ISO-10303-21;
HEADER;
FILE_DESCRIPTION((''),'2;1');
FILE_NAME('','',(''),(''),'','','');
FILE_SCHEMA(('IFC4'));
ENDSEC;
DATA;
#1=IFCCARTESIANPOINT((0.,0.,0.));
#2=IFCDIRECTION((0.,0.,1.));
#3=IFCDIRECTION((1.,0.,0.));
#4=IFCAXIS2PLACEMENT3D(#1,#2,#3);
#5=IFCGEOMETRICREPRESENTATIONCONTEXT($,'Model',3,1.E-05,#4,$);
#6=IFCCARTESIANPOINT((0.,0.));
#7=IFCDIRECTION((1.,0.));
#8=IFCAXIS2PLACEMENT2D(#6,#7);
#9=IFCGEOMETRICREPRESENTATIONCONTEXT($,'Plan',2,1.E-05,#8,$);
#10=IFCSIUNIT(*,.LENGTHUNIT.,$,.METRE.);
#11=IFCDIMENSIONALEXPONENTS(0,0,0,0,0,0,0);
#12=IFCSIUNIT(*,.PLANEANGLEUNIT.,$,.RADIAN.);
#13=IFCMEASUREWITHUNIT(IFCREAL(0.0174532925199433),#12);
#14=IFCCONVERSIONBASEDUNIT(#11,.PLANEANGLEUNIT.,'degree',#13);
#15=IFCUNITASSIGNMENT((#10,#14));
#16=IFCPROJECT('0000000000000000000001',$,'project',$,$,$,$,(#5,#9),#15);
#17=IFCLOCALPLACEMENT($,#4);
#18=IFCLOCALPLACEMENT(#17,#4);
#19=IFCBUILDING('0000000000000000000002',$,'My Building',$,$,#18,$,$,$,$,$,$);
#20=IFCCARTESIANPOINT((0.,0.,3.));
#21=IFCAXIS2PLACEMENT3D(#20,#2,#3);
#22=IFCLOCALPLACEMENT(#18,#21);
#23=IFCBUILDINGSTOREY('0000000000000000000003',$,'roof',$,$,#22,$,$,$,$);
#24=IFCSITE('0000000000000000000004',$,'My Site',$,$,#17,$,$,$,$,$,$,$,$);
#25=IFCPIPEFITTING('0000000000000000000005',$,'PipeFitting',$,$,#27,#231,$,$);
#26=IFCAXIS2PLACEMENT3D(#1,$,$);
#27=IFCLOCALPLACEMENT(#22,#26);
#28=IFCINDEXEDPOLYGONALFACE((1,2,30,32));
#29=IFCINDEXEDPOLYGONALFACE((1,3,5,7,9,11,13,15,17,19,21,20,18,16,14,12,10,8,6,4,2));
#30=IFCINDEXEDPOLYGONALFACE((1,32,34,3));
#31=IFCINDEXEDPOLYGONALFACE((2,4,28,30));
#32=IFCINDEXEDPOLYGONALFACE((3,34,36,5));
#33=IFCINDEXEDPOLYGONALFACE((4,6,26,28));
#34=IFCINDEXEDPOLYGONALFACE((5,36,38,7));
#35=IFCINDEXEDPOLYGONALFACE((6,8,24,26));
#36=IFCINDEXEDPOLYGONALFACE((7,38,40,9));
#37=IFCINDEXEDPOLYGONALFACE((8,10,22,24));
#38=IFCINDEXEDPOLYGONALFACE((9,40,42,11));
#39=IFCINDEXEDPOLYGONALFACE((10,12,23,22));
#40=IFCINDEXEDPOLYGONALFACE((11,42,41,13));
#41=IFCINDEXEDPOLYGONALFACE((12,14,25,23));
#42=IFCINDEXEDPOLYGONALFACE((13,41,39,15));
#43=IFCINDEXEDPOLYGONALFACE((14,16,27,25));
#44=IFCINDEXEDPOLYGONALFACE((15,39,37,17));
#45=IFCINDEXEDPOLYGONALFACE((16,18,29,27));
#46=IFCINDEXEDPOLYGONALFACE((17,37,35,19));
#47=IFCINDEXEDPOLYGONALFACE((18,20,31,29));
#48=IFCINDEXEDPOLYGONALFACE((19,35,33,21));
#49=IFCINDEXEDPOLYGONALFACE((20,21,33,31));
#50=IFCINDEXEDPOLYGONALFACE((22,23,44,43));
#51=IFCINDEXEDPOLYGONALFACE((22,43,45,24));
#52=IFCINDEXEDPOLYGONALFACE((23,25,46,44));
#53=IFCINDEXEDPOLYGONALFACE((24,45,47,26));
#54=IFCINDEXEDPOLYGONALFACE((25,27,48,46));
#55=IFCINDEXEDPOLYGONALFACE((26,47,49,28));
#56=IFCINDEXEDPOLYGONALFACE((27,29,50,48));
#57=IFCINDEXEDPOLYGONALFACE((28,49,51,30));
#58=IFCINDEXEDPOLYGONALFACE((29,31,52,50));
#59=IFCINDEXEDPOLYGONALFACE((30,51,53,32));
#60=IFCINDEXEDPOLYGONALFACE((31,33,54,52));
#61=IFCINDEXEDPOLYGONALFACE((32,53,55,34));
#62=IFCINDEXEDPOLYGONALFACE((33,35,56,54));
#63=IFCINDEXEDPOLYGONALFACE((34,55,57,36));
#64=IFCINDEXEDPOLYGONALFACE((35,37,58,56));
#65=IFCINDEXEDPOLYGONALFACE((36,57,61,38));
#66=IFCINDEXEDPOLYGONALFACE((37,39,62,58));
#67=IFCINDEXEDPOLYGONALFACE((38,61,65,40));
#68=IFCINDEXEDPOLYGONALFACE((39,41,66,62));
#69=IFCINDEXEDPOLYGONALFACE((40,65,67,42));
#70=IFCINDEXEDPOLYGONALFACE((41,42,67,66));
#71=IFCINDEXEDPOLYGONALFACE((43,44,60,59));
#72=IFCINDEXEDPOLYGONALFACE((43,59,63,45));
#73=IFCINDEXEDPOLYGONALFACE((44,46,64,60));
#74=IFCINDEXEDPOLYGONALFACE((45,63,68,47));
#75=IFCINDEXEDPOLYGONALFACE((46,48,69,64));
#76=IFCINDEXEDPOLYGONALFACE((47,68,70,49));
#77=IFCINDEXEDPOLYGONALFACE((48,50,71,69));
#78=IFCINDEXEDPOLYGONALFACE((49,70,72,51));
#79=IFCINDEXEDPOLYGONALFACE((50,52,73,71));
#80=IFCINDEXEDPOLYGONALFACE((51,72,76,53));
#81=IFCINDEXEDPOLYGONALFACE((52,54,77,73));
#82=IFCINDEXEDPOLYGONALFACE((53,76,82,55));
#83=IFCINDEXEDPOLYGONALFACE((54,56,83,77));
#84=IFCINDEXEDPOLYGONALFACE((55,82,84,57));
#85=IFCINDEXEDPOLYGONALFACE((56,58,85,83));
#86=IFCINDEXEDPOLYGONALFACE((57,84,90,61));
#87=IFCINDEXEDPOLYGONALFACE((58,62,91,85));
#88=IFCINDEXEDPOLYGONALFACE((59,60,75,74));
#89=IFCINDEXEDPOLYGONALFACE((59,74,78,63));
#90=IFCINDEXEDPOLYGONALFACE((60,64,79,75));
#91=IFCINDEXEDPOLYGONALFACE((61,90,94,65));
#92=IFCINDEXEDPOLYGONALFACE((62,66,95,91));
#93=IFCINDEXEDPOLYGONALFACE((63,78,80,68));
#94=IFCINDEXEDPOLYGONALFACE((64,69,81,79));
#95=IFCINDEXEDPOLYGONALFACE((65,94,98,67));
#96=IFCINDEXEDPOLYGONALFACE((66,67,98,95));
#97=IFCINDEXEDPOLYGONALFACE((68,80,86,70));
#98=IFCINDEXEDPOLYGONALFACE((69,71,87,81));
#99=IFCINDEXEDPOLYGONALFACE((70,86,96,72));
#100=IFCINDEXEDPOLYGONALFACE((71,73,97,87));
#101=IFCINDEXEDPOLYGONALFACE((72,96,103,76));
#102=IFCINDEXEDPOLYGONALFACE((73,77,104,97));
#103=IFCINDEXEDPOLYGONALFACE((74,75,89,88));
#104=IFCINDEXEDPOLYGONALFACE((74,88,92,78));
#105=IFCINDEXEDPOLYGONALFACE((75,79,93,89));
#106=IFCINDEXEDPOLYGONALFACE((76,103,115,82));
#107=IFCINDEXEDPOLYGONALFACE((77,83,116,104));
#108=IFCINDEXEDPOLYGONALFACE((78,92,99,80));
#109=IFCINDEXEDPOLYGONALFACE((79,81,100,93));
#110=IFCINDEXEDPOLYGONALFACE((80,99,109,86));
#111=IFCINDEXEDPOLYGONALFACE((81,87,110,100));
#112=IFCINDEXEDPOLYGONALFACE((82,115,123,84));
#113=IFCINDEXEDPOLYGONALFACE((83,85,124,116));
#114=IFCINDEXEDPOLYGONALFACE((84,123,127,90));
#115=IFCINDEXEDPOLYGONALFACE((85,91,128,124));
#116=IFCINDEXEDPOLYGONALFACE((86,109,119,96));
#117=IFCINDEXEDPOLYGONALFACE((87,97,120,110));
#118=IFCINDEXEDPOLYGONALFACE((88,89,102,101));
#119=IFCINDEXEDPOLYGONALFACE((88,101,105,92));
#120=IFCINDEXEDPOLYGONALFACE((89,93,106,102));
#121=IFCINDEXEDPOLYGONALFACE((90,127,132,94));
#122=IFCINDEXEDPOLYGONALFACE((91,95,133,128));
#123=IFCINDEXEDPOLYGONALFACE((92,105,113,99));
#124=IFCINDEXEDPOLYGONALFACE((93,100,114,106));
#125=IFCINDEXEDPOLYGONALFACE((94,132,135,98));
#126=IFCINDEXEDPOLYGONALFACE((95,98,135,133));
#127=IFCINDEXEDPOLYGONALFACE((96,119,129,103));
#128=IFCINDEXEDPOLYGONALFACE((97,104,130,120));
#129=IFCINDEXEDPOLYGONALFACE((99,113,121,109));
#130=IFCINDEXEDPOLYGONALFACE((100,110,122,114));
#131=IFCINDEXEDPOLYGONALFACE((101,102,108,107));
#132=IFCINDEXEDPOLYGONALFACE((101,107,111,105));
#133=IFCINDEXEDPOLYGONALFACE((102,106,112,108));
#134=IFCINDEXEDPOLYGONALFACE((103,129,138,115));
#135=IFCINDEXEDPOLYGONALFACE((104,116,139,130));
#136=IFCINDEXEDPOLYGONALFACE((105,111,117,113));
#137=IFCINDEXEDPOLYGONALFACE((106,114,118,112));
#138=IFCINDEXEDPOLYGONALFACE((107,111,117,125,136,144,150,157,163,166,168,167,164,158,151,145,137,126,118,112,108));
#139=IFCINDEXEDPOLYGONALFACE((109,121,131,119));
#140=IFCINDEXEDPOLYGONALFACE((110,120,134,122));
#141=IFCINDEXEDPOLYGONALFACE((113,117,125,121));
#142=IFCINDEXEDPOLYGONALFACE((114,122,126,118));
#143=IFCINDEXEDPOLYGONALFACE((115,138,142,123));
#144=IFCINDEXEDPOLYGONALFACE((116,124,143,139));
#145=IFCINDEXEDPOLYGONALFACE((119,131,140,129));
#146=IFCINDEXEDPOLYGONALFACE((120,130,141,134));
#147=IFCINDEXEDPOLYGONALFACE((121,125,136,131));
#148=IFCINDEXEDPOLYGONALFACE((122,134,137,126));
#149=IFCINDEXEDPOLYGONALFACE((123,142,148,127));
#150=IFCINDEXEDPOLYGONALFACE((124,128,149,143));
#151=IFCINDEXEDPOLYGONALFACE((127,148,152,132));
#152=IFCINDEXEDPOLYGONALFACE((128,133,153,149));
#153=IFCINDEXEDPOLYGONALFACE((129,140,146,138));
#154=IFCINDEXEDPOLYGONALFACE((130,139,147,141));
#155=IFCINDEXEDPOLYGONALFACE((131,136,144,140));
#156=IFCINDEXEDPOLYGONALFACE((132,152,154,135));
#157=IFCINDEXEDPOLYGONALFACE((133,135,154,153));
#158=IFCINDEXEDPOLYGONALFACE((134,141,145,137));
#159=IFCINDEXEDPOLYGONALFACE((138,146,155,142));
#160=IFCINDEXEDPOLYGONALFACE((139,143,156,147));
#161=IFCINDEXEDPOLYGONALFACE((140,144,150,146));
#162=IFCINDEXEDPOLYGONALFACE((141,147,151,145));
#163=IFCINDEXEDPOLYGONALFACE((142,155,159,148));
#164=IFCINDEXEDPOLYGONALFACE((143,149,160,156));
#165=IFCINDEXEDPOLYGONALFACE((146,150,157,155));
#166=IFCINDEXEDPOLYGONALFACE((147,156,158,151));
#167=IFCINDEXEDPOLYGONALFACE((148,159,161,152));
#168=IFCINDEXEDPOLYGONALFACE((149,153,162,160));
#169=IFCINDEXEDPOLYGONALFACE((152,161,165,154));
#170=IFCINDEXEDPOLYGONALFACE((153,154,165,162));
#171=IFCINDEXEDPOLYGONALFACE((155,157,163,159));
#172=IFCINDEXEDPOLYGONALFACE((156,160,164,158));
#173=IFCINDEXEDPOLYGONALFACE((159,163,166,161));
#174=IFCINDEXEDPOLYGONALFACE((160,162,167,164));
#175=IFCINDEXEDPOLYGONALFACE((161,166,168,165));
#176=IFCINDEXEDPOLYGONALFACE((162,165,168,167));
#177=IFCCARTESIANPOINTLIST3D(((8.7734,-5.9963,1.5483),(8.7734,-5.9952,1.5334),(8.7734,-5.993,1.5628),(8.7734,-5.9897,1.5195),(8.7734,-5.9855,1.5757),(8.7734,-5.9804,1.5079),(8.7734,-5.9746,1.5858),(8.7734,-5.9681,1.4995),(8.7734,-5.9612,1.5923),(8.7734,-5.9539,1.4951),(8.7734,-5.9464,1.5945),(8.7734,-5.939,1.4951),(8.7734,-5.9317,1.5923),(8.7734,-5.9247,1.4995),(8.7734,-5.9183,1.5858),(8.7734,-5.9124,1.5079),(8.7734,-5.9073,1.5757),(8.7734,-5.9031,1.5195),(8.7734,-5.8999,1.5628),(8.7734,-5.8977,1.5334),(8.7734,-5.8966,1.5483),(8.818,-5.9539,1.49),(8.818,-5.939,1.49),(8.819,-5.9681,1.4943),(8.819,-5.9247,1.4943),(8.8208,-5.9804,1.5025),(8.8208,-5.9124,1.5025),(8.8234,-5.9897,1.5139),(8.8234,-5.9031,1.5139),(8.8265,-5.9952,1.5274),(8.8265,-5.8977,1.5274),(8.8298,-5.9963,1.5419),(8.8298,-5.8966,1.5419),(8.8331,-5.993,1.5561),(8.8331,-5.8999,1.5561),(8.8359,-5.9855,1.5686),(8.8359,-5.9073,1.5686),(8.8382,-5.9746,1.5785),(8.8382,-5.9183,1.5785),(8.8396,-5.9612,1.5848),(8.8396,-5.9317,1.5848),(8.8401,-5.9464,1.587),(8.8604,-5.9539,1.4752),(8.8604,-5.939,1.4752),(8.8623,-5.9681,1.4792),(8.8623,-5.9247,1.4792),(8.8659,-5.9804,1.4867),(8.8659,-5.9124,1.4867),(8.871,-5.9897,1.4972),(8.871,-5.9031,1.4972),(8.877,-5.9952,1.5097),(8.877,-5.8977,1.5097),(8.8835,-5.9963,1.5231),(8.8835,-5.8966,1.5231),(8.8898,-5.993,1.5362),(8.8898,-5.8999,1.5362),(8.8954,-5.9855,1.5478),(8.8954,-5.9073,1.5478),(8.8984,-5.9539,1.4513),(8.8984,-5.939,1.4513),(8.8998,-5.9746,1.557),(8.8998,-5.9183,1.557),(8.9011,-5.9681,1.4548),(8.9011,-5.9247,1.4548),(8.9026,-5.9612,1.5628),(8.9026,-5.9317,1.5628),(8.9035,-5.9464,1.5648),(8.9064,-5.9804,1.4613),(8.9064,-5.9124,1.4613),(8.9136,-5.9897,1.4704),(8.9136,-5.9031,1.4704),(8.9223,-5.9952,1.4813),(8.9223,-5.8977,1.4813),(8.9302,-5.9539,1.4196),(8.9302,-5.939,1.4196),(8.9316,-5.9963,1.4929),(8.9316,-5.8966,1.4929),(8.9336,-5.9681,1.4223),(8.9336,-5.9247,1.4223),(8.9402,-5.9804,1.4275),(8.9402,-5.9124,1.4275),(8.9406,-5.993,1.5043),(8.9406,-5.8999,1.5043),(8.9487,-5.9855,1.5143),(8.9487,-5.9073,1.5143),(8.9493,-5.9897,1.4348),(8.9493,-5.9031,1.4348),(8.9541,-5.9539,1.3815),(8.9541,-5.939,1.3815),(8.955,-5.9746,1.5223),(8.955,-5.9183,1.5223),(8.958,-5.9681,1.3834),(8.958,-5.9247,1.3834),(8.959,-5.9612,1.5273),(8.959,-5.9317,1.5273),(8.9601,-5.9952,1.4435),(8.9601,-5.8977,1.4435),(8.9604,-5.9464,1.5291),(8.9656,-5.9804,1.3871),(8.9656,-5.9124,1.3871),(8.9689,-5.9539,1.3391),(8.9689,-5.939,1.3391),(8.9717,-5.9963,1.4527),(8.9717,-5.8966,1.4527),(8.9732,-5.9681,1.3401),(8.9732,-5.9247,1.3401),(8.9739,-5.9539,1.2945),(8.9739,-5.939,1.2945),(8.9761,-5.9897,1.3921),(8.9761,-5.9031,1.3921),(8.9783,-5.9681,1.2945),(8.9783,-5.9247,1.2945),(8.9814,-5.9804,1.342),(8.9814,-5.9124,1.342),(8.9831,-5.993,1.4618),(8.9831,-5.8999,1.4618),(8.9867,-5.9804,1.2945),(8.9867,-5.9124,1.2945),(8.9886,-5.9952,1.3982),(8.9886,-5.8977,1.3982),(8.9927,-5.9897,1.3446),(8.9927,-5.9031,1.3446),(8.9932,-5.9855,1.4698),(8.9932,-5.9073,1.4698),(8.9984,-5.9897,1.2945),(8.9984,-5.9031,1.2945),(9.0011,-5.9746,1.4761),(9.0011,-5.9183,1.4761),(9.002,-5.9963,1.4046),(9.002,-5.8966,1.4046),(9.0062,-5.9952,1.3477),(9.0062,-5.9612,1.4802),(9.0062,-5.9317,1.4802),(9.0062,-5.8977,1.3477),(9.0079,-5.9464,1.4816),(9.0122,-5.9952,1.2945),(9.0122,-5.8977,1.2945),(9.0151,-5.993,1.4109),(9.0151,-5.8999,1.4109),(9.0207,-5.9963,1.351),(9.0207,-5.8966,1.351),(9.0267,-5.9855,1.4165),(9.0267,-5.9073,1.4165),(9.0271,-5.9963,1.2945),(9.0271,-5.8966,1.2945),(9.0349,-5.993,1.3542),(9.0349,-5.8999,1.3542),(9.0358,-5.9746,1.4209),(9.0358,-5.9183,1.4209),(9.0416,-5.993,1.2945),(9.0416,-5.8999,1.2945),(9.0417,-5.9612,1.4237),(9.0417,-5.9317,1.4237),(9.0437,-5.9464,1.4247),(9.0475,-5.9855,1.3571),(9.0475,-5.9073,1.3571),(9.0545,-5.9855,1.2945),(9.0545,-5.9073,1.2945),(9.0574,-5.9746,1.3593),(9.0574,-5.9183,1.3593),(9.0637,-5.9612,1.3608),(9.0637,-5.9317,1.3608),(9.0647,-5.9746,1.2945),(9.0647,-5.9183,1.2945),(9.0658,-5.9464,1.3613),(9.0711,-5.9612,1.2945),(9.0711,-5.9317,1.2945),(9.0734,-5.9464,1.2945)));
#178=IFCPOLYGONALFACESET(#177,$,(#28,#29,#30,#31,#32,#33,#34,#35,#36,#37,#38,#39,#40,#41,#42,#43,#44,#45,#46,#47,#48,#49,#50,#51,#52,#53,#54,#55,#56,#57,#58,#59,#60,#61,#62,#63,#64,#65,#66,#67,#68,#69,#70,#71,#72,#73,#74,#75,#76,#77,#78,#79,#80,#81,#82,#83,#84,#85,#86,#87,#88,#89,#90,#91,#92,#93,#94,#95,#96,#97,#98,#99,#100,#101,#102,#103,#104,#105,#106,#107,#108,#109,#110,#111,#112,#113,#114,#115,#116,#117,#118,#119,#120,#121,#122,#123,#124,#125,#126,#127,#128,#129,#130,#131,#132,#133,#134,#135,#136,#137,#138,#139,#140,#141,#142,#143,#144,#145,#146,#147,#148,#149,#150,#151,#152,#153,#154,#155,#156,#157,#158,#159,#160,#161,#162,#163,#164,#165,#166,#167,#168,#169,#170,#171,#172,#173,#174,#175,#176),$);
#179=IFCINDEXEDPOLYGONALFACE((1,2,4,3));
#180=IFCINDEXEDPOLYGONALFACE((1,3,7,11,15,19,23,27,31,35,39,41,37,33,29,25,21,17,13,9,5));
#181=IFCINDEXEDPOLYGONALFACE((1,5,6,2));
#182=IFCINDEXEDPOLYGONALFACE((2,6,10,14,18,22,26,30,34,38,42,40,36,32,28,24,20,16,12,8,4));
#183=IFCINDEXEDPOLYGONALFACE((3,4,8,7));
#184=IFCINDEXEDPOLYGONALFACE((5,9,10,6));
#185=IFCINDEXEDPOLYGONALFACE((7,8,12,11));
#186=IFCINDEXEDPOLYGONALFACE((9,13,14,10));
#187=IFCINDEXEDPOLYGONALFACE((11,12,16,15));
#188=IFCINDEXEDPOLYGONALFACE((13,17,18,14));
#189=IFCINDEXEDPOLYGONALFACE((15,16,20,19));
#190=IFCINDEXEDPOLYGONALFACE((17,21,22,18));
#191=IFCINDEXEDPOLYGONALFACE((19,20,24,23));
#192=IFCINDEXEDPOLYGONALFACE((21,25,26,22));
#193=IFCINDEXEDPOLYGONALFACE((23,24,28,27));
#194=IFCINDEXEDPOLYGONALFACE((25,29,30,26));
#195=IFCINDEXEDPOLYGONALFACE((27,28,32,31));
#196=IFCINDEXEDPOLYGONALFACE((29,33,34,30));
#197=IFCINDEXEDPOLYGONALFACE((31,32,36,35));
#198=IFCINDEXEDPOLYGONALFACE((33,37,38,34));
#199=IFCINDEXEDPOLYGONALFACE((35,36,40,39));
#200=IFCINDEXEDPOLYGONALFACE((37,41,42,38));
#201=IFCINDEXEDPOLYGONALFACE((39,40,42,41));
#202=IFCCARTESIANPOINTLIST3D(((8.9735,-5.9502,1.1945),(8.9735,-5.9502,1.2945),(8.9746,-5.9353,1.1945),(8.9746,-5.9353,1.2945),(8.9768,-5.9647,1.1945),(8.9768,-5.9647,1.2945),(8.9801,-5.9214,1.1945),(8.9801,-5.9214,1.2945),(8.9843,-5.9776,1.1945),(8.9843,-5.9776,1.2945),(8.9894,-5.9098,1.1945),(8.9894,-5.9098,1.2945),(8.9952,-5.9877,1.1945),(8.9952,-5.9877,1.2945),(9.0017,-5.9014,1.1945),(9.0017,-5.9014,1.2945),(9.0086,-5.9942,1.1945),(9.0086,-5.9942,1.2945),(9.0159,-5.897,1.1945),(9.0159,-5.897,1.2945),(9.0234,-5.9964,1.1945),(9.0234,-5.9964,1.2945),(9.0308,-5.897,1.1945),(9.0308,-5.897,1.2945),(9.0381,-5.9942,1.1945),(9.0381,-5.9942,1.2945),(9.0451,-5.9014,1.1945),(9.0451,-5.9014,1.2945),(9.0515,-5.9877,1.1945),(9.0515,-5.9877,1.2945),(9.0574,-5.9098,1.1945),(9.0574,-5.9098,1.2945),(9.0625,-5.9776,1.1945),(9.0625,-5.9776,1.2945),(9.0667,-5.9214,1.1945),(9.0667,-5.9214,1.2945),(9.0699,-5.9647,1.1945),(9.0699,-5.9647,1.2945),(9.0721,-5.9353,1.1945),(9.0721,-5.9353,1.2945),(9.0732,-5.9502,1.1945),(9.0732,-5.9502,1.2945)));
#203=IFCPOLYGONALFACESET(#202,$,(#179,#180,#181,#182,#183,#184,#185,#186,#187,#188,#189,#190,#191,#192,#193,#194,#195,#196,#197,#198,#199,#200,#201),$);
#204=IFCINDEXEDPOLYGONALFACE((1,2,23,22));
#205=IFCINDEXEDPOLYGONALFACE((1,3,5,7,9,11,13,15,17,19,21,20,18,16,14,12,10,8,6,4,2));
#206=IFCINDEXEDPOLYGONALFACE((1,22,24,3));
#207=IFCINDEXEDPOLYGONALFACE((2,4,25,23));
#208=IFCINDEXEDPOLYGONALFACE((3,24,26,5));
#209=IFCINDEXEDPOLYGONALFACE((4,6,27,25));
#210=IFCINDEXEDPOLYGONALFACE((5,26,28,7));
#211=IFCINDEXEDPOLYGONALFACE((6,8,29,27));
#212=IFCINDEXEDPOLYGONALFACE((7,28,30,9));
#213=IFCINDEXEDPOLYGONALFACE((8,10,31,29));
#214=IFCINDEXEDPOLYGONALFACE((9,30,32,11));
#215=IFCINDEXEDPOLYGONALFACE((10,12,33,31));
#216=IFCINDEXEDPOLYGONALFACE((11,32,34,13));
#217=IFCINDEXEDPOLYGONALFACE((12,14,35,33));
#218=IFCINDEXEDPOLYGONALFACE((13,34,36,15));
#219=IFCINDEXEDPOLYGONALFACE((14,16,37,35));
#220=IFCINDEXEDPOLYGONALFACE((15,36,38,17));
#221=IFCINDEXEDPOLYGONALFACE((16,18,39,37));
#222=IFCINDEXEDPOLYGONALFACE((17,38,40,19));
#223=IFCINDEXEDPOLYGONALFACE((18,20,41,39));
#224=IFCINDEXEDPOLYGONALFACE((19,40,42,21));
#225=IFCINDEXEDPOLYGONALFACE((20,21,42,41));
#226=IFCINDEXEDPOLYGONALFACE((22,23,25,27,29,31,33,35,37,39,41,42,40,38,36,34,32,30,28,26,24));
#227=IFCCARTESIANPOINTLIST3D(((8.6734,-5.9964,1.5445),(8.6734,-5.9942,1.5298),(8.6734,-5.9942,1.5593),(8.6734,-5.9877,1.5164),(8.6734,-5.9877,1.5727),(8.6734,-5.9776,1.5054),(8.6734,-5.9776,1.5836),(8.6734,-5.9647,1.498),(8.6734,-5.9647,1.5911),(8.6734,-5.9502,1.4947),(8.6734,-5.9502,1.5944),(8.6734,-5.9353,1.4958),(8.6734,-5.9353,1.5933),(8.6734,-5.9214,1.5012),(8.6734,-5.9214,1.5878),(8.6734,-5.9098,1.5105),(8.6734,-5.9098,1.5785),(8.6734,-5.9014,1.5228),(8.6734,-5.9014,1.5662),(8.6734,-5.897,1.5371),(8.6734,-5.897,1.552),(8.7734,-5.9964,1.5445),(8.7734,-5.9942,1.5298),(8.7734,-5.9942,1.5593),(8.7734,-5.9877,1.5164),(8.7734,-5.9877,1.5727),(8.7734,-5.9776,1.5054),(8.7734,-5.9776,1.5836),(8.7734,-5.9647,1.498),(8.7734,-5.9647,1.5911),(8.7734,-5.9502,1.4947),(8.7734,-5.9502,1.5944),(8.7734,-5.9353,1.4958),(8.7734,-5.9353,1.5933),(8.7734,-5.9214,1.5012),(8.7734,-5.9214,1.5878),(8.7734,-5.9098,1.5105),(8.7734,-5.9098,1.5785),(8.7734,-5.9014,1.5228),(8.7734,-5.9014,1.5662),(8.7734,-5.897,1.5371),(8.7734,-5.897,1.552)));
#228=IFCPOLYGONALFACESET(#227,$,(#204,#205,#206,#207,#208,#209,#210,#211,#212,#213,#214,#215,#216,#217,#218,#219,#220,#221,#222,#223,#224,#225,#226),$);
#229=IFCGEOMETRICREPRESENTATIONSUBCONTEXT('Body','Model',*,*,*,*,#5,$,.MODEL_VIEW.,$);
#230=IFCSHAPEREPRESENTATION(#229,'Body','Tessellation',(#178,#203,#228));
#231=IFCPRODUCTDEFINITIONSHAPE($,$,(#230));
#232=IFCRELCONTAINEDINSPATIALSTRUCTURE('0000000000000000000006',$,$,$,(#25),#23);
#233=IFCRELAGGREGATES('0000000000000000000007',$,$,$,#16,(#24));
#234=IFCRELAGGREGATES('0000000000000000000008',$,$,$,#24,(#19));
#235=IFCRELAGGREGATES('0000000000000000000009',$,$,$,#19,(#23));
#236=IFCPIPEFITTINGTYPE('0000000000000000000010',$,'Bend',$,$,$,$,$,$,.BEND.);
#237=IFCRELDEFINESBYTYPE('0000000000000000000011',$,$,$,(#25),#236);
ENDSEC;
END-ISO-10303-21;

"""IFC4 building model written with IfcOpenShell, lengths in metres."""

from ifc_helpers import new_model, entity, si_unit, converted_unit, frame, origin_with_axes, origin_2d_with_axis, place, context, subcontext, project, spatial, circle, extrude, source, transform, mapped, type_object, type_shapes, element, save


model = new_model("IFC4")

# Units and contexts
model_context = context("Model", 3, precision=1e-05, world=origin_with_axes())
plan_context = context("Plan", 2, precision=1e-05, world=origin_2d_with_axis())
body_context = subcontext(model_context, "Body", "Model", "MODEL_VIEW")
ifc_project = project(units=[si_unit("LENGTHUNIT", "METRE"), converted_unit("PLANEANGLEUNIT", "degree", entity("IfcReal", 0.0174532925199433), si_unit("PLANEANGLEUNIT", "RADIAN"), dimensions=[0, 0, 0, 0, 0, 0, 0])], contexts=[model_context, plan_context])

# Site, building, storey
site_placement = place(None, origin_with_axes())
site = spatial("IfcSite", under=ifc_project, at=site_placement, Name="My Site")
building_placement = place(site_placement, origin_with_axes())
building = spatial("IfcBuilding", under=site, at=building_placement, Name="My Building")
storey_placement = place(building_placement, frame((0.0, 0.0, 3.0), z_axis=(0.0, 0.0, 1.0), x_axis=(1.0, 0.0, 0.0)))
storey = spatial("IfcBuildingStorey", under=building, at=storey_placement, Name="roof")

# Pipe fitting
pipe_fitting_type_1 = type_object("IfcPipeFittingType", Name="Bend", PredefinedType="BEND")
shared_shape = source(origin_with_axes(), body_context, "Body", "SolidModel", [
    entity("IfcSweptDiskSolid", entity("IfcIndexedPolyCurve", entity("IfcCartesianPointList3D", [[0.0, 0.0, 0.1], [0.0, -0.0732, 0.2768], [0.0, -0.25, 0.35]]), [entity("IfcArcIndex", [1, 2, 3])]), 0.05),
    extrude(circle(Radius=0.05), origin_with_axes(), (0.0, 0.0, 1.0), 0.1),
    extrude(circle(Radius=0.05), frame((0.0, -0.25, 0.35), z_axis=(0.0, -1.0, 0.0), x_axis=(1.0, 0.0, 0.0)), (0.0, 0.0, 1.0), 0.1),
])
type_shapes(pipe_fitting_type_1, [shared_shape])
for number, where, z_axis, x_axis, name in (
    (1, (9.0234, -5.9464, 1.1945), (0.000001, -0.000001, 1.0), (0.0, -1.0, -0.000001), "PipeFitting"),
):
    element("IfcPipeFitting", number, at=place(storey_placement, frame(where, z_axis=z_axis, x_axis=x_axis)), inside=storey, type_object=pipe_fitting_type_1, Name=name, context=body_context, shape_type="MappedRepresentation", body=[
        mapped(shared_shape, transform((0.0, 0.0, 0.0), x_axis=(1.0, 0.0, 0.0), y_axis=(0.0, 1.0, 0.0), z_axis=(0.0, 0.0, 1.0), scale=1.0)),
    ])

save(model, "model.ifc")
